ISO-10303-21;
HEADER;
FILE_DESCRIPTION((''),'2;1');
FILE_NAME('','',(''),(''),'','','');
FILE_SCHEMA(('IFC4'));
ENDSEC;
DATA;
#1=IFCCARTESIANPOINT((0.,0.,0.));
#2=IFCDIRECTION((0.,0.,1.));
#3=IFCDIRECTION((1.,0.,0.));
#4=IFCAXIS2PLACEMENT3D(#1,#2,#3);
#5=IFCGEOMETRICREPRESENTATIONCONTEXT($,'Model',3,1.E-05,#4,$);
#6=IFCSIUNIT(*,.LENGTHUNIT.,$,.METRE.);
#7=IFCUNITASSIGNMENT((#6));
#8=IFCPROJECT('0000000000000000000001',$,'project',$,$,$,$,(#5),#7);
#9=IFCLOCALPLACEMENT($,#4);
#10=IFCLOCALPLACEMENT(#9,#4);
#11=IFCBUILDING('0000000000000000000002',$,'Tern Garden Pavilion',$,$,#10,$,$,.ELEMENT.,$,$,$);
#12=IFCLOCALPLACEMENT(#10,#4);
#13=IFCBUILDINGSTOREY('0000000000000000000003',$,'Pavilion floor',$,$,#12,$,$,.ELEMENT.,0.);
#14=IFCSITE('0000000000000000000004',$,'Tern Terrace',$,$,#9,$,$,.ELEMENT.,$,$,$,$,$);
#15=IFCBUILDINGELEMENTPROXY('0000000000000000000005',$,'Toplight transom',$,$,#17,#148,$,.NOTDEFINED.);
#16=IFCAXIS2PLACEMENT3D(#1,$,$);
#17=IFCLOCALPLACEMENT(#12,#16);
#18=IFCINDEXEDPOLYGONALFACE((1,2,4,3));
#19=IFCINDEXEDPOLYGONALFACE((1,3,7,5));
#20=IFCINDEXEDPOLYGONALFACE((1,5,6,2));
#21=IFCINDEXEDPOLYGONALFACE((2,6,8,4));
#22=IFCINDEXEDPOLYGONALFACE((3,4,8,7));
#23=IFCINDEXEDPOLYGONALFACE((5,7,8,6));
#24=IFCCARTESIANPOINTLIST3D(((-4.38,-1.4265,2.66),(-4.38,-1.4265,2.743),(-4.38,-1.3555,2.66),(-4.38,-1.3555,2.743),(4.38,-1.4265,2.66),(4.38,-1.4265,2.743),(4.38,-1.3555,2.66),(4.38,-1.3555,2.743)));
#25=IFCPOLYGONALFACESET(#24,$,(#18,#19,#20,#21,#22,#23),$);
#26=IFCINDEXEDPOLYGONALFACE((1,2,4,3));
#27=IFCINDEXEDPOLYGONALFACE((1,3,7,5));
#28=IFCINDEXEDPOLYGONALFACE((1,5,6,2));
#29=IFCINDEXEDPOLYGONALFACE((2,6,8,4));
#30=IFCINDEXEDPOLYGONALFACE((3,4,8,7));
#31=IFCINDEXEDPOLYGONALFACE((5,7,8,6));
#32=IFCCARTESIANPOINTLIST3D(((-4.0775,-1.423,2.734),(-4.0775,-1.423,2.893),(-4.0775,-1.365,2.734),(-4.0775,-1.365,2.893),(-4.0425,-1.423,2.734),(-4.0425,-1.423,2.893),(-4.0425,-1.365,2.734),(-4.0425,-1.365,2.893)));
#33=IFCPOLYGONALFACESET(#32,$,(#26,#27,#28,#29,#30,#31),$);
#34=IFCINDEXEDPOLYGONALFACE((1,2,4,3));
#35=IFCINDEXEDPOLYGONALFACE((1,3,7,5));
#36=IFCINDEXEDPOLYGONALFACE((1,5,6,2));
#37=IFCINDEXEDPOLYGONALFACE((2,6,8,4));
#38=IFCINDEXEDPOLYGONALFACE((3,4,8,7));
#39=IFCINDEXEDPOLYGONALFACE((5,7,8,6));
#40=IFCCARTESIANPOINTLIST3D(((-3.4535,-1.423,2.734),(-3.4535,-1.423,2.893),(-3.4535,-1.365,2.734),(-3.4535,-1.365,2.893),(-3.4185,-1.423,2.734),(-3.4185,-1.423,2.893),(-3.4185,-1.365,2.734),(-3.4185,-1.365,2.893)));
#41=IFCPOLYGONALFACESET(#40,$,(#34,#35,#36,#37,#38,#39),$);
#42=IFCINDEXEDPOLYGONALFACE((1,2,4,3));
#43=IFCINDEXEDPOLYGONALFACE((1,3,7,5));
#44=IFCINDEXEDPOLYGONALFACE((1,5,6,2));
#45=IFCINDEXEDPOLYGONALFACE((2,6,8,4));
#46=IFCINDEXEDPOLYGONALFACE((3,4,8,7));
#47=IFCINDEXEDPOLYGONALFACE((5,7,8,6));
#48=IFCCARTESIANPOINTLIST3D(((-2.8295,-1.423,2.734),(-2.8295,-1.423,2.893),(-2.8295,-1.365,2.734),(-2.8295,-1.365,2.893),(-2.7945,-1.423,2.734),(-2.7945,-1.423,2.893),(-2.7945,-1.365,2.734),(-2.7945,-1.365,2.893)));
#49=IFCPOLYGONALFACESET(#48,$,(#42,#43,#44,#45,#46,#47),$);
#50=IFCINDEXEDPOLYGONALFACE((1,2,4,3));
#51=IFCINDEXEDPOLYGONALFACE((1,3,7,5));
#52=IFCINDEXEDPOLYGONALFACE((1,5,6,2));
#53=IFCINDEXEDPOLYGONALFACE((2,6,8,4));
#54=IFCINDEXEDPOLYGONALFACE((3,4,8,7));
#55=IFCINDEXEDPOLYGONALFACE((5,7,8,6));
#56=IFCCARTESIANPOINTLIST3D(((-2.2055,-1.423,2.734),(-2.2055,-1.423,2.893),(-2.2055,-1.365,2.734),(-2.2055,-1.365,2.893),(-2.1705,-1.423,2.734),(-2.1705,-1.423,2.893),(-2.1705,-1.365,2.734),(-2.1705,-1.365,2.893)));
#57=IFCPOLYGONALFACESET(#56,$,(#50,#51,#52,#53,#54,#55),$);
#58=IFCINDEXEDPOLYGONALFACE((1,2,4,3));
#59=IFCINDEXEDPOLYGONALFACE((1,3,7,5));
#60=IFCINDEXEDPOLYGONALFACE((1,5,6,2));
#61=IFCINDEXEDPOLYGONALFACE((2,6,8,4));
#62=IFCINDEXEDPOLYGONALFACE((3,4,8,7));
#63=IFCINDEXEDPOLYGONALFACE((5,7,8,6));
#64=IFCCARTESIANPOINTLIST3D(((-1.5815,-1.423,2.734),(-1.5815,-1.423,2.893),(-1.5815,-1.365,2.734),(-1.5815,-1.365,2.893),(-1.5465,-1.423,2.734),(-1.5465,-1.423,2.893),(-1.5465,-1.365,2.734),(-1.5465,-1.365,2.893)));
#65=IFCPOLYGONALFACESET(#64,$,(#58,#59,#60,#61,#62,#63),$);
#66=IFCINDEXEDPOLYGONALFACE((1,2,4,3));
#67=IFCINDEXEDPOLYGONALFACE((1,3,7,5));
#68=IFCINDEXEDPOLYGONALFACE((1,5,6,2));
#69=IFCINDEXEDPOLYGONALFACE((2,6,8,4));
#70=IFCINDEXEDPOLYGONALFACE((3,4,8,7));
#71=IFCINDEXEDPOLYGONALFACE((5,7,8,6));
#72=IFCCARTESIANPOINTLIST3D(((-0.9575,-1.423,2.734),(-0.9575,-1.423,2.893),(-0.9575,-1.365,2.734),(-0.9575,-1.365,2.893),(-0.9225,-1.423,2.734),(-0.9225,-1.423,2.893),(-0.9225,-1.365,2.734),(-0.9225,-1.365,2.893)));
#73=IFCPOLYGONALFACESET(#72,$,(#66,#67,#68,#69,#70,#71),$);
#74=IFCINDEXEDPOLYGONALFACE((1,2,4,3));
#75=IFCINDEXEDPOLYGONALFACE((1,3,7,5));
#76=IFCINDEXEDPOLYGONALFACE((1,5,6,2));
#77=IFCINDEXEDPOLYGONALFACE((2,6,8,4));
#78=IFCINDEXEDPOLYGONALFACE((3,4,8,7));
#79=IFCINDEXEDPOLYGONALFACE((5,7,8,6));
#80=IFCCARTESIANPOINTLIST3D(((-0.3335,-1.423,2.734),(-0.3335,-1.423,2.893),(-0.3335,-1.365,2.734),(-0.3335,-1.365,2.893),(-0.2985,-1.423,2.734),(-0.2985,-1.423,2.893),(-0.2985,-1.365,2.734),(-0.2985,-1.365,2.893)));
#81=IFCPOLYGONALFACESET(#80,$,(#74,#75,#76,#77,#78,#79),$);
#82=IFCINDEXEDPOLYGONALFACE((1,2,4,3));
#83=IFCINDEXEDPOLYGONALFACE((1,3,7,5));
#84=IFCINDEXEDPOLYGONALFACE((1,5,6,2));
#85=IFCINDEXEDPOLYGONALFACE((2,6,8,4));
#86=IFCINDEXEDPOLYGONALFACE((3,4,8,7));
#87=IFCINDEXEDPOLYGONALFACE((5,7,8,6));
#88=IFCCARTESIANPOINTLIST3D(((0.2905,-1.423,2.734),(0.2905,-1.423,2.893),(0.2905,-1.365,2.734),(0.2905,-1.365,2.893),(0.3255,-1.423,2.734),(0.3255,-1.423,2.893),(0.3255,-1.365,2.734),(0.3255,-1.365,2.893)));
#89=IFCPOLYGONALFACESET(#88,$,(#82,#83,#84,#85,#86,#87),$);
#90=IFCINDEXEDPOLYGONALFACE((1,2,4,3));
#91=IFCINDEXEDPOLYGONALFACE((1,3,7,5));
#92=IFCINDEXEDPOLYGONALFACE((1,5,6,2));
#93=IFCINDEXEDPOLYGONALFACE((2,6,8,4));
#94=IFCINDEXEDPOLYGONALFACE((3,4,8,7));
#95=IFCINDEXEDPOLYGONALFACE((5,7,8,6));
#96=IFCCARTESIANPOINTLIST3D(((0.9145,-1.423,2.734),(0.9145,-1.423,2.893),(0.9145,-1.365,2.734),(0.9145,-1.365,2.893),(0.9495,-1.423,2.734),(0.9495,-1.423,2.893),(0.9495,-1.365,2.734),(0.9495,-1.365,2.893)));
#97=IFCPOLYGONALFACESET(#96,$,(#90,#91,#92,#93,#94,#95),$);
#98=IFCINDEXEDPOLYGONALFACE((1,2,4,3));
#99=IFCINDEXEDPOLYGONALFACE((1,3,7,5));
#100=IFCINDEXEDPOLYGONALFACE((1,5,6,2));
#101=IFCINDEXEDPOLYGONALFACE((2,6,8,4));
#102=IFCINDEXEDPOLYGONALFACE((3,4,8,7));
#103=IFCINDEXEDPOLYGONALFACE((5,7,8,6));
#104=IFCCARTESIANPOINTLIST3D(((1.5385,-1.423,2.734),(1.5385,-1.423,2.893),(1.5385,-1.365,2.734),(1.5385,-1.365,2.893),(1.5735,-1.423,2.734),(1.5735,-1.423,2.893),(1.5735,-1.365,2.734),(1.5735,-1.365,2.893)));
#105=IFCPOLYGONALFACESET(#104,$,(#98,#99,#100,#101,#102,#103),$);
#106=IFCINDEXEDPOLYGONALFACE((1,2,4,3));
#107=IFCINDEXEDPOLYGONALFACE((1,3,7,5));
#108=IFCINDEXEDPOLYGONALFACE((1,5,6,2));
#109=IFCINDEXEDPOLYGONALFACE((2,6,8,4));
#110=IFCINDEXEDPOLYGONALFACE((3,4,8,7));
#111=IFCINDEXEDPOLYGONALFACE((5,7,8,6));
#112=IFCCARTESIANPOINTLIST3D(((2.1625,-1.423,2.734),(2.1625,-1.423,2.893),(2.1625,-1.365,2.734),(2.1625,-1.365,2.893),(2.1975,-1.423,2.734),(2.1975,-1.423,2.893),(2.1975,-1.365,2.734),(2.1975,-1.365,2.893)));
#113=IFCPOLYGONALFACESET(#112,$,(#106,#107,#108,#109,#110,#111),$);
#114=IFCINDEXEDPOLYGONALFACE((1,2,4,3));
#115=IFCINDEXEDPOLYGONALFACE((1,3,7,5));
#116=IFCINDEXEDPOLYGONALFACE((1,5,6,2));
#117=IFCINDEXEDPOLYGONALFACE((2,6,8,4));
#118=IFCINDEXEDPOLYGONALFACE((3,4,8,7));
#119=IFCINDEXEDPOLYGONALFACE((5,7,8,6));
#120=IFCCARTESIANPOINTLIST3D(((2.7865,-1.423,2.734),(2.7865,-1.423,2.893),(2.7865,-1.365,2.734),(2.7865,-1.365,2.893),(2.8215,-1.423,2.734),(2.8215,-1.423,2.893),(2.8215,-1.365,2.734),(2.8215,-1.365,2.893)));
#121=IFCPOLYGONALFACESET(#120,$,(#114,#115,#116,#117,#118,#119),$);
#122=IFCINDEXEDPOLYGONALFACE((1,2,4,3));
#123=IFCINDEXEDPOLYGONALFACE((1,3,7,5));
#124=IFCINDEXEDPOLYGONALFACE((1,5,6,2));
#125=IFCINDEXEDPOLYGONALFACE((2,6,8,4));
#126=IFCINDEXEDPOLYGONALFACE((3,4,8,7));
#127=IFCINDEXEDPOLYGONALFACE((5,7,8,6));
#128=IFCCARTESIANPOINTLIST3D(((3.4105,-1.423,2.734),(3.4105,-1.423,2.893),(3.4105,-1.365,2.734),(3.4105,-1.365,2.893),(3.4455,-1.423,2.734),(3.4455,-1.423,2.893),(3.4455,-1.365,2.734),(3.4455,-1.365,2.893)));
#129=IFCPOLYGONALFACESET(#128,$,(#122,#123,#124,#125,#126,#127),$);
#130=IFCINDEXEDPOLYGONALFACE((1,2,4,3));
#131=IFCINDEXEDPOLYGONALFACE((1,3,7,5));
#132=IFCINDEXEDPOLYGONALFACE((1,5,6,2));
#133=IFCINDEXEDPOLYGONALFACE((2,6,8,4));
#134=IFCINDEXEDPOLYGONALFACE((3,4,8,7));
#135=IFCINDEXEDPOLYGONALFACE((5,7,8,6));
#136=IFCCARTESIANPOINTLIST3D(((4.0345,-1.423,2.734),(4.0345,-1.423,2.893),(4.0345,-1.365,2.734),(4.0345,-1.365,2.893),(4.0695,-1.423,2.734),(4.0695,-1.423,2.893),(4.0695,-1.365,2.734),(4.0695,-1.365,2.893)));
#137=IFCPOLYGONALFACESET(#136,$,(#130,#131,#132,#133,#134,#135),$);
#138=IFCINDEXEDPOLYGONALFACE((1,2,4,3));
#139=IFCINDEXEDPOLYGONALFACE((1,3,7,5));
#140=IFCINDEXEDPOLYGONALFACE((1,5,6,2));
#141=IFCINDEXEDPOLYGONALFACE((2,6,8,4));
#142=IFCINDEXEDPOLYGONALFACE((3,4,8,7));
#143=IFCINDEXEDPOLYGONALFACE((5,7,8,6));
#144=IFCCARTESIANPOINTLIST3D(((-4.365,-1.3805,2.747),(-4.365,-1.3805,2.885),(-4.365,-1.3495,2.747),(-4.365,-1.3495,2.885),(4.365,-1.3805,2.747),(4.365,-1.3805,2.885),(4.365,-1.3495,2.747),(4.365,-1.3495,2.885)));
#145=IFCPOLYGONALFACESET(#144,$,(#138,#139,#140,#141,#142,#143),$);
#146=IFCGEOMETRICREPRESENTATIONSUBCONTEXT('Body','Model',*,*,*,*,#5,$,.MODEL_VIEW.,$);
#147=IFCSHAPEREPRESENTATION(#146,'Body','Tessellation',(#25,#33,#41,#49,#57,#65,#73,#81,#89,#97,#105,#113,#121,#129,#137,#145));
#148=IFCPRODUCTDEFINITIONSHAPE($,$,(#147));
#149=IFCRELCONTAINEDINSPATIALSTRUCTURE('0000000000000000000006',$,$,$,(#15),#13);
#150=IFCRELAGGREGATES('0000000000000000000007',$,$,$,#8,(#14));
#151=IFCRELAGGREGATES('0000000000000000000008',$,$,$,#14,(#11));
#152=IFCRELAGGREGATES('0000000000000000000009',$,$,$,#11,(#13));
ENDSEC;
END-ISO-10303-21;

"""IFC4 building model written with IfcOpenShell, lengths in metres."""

from ifc_helpers import new_model, si_unit, frame, origin_with_axes, origin_2d, place, context, subcontext, project, spatial, rectangle, extrude, element, save


model = new_model("IFC4")

# Units and contexts
model_context = context("Model", 3, precision=1e-05, world=origin_with_axes())
body_context = subcontext(model_context, "Body", "Model", "MODEL_VIEW")
ifc_project = project(units=[si_unit("LENGTHUNIT", "METRE")], contexts=[model_context])

# Site, building, storey
site_placement = place(None, origin_with_axes())
site = spatial("IfcSite", under=ifc_project, at=site_placement, Name="Tern Terrace", CompositionType="ELEMENT")
building_placement = place(site_placement, origin_with_axes())
building = spatial("IfcBuilding", under=site, at=building_placement, Name="Tern Garden Pavilion", CompositionType="ELEMENT")
storey_placement = place(building_placement, origin_with_axes())
storey = spatial("IfcBuildingStorey", under=building, at=storey_placement, Name="Pavilion floor", CompositionType="ELEMENT", Elevation=0.0)

# Building element proxy
proxy_1_placement = place(storey_placement, origin_with_axes())
element("IfcBuildingElementProxy", 1, at=proxy_1_placement, inside=storey, Name="Toplight transom", PredefinedType="NOTDEFINED", context=body_context, shape_type="SweptSolid", body=[
    extrude(rectangle(XDim=8.76, YDim=0.071, at=origin_2d()), frame((0.0, -1.391, 2.66), z_axis=(0.0, 0.0, 1.0), x_axis=(1.0, 0.0, 0.0)), (0.0, 0.0, 1.0), 0.083),
    extrude(rectangle(XDim=0.035, YDim=0.058, at=origin_2d()), frame((-4.06, -1.394, 2.734), z_axis=(0.0, 0.0, 1.0), x_axis=(1.0, 0.0, 0.0)), (0.0, 0.0, 1.0), 0.159),
    extrude(rectangle(XDim=0.035, YDim=0.058, at=origin_2d()), frame((-3.436, -1.394, 2.734), z_axis=(0.0, 0.0, 1.0), x_axis=(1.0, 0.0, 0.0)), (0.0, 0.0, 1.0), 0.159),
    extrude(rectangle(XDim=0.035, YDim=0.058, at=origin_2d()), frame((-2.812, -1.394, 2.734), z_axis=(0.0, 0.0, 1.0), x_axis=(1.0, 0.0, 0.0)), (0.0, 0.0, 1.0), 0.159),
    extrude(rectangle(XDim=0.035, YDim=0.058, at=origin_2d()), frame((-2.188, -1.394, 2.734), z_axis=(0.0, 0.0, 1.0), x_axis=(1.0, 0.0, 0.0)), (0.0, 0.0, 1.0), 0.159),
    extrude(rectangle(XDim=0.035, YDim=0.058, at=origin_2d()), frame((-1.564, -1.394, 2.734), z_axis=(0.0, 0.0, 1.0), x_axis=(1.0, 0.0, 0.0)), (0.0, 0.0, 1.0), 0.159),
    extrude(rectangle(XDim=0.035, YDim=0.058, at=origin_2d()), frame((-0.94, -1.394, 2.734), z_axis=(0.0, 0.0, 1.0), x_axis=(1.0, 0.0, 0.0)), (0.0, 0.0, 1.0), 0.159),
    extrude(rectangle(XDim=0.035, YDim=0.058, at=origin_2d()), frame((-0.316, -1.394, 2.734), z_axis=(0.0, 0.0, 1.0), x_axis=(1.0, 0.0, 0.0)), (0.0, 0.0, 1.0), 0.159),
    extrude(rectangle(XDim=0.035, YDim=0.058, at=origin_2d()), frame((0.308, -1.394, 2.734), z_axis=(0.0, 0.0, 1.0), x_axis=(1.0, 0.0, 0.0)), (0.0, 0.0, 1.0), 0.159),
    extrude(rectangle(XDim=0.035, YDim=0.058, at=origin_2d()), frame((0.932, -1.394, 2.734), z_axis=(0.0, 0.0, 1.0), x_axis=(1.0, 0.0, 0.0)), (0.0, 0.0, 1.0), 0.159),
    extrude(rectangle(XDim=0.035, YDim=0.058, at=origin_2d()), frame((1.556, -1.394, 2.734), z_axis=(0.0, 0.0, 1.0), x_axis=(1.0, 0.0, 0.0)), (0.0, 0.0, 1.0), 0.159),
    extrude(rectangle(XDim=0.035, YDim=0.058, at=origin_2d()), frame((2.18, -1.394, 2.734), z_axis=(0.0, 0.0, 1.0), x_axis=(1.0, 0.0, 0.0)), (0.0, 0.0, 1.0), 0.159),
    extrude(rectangle(XDim=0.035, YDim=0.058, at=origin_2d()), frame((2.804, -1.394, 2.734), z_axis=(0.0, 0.0, 1.0), x_axis=(1.0, 0.0, 0.0)), (0.0, 0.0, 1.0), 0.159),
    extrude(rectangle(XDim=0.035, YDim=0.058, at=origin_2d()), frame((3.428, -1.394, 2.734), z_axis=(0.0, 0.0, 1.0), x_axis=(1.0, 0.0, 0.0)), (0.0, 0.0, 1.0), 0.159),
    extrude(rectangle(XDim=0.035, YDim=0.058, at=origin_2d()), frame((4.052, -1.394, 2.734), z_axis=(0.0, 0.0, 1.0), x_axis=(1.0, 0.0, 0.0)), (0.0, 0.0, 1.0), 0.159),
    extrude(rectangle(XDim=8.73, YDim=0.031, at=origin_2d()), frame((0.0, -1.365, 2.747), z_axis=(0.0, 0.0, 1.0), x_axis=(1.0, 0.0, 0.0)), (0.0, 0.0, 1.0), 0.138),
])

save(model, "model.ifc")
